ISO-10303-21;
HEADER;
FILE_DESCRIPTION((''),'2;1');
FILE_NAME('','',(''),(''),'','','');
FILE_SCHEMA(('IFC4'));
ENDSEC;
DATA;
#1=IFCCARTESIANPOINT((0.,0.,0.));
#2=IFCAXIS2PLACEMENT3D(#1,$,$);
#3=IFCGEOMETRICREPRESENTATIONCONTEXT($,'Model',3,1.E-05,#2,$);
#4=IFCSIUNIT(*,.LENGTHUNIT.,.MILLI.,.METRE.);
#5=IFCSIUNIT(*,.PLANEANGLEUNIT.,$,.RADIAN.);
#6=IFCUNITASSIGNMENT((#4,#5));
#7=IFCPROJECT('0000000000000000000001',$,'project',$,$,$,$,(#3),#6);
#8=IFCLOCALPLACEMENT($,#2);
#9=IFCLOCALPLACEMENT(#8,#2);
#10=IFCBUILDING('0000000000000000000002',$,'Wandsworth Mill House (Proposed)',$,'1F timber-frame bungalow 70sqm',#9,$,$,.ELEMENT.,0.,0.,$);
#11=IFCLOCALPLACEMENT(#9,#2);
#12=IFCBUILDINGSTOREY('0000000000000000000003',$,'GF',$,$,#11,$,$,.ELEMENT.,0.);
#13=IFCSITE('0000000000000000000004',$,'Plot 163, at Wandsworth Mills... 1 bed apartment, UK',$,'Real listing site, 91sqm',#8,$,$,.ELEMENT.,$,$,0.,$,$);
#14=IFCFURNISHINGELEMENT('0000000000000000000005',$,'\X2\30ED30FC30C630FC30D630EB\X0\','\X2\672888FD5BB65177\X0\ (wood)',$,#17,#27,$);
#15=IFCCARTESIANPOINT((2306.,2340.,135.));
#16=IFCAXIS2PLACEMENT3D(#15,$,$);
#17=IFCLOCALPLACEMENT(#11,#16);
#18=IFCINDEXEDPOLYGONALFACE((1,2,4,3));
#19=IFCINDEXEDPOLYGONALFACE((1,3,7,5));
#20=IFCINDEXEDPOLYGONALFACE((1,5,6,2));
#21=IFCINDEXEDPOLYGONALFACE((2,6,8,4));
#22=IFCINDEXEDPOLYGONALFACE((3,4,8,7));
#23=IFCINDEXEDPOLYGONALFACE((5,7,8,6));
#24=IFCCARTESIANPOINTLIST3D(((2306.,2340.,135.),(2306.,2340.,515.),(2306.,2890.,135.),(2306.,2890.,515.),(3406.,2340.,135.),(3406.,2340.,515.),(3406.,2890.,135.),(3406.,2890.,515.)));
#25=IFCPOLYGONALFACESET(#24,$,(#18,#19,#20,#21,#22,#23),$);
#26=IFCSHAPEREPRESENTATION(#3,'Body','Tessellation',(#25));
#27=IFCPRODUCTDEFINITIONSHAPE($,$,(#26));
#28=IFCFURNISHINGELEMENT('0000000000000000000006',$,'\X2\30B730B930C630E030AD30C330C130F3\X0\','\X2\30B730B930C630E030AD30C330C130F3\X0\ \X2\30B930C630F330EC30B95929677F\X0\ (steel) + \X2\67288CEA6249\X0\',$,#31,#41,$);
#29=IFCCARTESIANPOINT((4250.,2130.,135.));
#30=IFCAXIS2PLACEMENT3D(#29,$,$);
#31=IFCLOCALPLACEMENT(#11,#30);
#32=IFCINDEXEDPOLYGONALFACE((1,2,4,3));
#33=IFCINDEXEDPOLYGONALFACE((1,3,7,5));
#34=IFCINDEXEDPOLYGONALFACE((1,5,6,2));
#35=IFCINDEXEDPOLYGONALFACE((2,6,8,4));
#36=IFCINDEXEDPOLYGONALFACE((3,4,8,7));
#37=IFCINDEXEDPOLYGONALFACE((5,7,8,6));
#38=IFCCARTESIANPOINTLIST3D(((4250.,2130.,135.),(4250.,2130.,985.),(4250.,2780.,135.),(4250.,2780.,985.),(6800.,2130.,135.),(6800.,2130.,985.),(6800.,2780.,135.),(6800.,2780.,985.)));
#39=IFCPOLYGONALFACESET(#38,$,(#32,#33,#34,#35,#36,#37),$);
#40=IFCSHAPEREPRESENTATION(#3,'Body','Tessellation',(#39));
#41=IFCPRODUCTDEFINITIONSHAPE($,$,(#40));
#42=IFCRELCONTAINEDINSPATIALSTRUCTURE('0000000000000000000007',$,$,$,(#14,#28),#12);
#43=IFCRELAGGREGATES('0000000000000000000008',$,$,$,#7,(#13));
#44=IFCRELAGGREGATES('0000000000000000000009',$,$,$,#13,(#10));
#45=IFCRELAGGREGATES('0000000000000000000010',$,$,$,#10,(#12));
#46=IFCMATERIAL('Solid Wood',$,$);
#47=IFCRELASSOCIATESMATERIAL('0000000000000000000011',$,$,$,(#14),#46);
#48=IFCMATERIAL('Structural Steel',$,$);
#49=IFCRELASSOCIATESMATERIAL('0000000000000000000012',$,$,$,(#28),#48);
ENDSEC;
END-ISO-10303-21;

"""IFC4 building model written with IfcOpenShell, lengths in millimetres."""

from ifc_helpers import new_model, si_unit, frame, frame_2d, origin, place, context, project, spatial, rectangle, extrude, material, element, save


model = new_model("IFC4")

# Units and contexts
model_context = context("Model", 3, precision=1e-05, world=origin())
ifc_project = project(units=[si_unit("LENGTHUNIT", "METRE", prefix="MILLI"), si_unit("PLANEANGLEUNIT", "RADIAN")], contexts=[model_context])

# Site, building, storey
site_placement = place(None, origin())
site = spatial("IfcSite", under=ifc_project, at=site_placement, Name="Plot 163, at Wandsworth Mills... 1 bed apartment, UK", ObjectType="Real listing site, 91sqm", CompositionType="ELEMENT", RefElevation=0.0)
building_placement = place(site_placement, origin())
building = spatial("IfcBuilding", under=site, at=building_placement, Name="Wandsworth Mill House (Proposed)", ObjectType="1F timber-frame bungalow 70sqm", CompositionType="ELEMENT", ElevationOfRefHeight=0.0, ElevationOfTerrain=0.0)
storey_placement = place(building_placement, origin())
storey = spatial("IfcBuildingStorey", under=building, at=storey_placement, Name="GF", CompositionType="ELEMENT", Elevation=0.0)

# Shared definitions
ifc_material_1 = material(Name="Solid Wood")

# Furnishing elements
furnishing_1_placement = place(storey_placement, frame((2306.0, 2340.0, 135.0)))
element("IfcFurnishingElement", 1, at=furnishing_1_placement, inside=storey, material=ifc_material_1, Name="ローテーブル", Description="木製家具 (wood)", context=model_context, shape_type="SweptSolid", body=[
    extrude(rectangle(XDim=1100.0, YDim=550.0, at=frame_2d((550.0, 275.0))), frame((2306.0, 2340.0, 135.0)), (0.0, 0.0, 1.0), 380.0),
])
ifc_material_2 = material(Name="Structural Steel")
furnishing_2_placement = place(storey_placement, frame((4250.0, 2130.0, 135.0)))
element("IfcFurnishingElement", 2, at=furnishing_2_placement, inside=storey, material=ifc_material_2, Name="システムキッチン", Description="システムキッチン ステンレス天板 (steel) + 木質扉", context=model_context, shape_type="SweptSolid", body=[
    extrude(rectangle(XDim=2550.0, YDim=650.0, at=frame_2d((1275.0, 325.0))), frame((4250.0, 2130.0, 135.0)), (0.0, 0.0, 1.0), 850.0),
])

save(model, "model.ifc")
